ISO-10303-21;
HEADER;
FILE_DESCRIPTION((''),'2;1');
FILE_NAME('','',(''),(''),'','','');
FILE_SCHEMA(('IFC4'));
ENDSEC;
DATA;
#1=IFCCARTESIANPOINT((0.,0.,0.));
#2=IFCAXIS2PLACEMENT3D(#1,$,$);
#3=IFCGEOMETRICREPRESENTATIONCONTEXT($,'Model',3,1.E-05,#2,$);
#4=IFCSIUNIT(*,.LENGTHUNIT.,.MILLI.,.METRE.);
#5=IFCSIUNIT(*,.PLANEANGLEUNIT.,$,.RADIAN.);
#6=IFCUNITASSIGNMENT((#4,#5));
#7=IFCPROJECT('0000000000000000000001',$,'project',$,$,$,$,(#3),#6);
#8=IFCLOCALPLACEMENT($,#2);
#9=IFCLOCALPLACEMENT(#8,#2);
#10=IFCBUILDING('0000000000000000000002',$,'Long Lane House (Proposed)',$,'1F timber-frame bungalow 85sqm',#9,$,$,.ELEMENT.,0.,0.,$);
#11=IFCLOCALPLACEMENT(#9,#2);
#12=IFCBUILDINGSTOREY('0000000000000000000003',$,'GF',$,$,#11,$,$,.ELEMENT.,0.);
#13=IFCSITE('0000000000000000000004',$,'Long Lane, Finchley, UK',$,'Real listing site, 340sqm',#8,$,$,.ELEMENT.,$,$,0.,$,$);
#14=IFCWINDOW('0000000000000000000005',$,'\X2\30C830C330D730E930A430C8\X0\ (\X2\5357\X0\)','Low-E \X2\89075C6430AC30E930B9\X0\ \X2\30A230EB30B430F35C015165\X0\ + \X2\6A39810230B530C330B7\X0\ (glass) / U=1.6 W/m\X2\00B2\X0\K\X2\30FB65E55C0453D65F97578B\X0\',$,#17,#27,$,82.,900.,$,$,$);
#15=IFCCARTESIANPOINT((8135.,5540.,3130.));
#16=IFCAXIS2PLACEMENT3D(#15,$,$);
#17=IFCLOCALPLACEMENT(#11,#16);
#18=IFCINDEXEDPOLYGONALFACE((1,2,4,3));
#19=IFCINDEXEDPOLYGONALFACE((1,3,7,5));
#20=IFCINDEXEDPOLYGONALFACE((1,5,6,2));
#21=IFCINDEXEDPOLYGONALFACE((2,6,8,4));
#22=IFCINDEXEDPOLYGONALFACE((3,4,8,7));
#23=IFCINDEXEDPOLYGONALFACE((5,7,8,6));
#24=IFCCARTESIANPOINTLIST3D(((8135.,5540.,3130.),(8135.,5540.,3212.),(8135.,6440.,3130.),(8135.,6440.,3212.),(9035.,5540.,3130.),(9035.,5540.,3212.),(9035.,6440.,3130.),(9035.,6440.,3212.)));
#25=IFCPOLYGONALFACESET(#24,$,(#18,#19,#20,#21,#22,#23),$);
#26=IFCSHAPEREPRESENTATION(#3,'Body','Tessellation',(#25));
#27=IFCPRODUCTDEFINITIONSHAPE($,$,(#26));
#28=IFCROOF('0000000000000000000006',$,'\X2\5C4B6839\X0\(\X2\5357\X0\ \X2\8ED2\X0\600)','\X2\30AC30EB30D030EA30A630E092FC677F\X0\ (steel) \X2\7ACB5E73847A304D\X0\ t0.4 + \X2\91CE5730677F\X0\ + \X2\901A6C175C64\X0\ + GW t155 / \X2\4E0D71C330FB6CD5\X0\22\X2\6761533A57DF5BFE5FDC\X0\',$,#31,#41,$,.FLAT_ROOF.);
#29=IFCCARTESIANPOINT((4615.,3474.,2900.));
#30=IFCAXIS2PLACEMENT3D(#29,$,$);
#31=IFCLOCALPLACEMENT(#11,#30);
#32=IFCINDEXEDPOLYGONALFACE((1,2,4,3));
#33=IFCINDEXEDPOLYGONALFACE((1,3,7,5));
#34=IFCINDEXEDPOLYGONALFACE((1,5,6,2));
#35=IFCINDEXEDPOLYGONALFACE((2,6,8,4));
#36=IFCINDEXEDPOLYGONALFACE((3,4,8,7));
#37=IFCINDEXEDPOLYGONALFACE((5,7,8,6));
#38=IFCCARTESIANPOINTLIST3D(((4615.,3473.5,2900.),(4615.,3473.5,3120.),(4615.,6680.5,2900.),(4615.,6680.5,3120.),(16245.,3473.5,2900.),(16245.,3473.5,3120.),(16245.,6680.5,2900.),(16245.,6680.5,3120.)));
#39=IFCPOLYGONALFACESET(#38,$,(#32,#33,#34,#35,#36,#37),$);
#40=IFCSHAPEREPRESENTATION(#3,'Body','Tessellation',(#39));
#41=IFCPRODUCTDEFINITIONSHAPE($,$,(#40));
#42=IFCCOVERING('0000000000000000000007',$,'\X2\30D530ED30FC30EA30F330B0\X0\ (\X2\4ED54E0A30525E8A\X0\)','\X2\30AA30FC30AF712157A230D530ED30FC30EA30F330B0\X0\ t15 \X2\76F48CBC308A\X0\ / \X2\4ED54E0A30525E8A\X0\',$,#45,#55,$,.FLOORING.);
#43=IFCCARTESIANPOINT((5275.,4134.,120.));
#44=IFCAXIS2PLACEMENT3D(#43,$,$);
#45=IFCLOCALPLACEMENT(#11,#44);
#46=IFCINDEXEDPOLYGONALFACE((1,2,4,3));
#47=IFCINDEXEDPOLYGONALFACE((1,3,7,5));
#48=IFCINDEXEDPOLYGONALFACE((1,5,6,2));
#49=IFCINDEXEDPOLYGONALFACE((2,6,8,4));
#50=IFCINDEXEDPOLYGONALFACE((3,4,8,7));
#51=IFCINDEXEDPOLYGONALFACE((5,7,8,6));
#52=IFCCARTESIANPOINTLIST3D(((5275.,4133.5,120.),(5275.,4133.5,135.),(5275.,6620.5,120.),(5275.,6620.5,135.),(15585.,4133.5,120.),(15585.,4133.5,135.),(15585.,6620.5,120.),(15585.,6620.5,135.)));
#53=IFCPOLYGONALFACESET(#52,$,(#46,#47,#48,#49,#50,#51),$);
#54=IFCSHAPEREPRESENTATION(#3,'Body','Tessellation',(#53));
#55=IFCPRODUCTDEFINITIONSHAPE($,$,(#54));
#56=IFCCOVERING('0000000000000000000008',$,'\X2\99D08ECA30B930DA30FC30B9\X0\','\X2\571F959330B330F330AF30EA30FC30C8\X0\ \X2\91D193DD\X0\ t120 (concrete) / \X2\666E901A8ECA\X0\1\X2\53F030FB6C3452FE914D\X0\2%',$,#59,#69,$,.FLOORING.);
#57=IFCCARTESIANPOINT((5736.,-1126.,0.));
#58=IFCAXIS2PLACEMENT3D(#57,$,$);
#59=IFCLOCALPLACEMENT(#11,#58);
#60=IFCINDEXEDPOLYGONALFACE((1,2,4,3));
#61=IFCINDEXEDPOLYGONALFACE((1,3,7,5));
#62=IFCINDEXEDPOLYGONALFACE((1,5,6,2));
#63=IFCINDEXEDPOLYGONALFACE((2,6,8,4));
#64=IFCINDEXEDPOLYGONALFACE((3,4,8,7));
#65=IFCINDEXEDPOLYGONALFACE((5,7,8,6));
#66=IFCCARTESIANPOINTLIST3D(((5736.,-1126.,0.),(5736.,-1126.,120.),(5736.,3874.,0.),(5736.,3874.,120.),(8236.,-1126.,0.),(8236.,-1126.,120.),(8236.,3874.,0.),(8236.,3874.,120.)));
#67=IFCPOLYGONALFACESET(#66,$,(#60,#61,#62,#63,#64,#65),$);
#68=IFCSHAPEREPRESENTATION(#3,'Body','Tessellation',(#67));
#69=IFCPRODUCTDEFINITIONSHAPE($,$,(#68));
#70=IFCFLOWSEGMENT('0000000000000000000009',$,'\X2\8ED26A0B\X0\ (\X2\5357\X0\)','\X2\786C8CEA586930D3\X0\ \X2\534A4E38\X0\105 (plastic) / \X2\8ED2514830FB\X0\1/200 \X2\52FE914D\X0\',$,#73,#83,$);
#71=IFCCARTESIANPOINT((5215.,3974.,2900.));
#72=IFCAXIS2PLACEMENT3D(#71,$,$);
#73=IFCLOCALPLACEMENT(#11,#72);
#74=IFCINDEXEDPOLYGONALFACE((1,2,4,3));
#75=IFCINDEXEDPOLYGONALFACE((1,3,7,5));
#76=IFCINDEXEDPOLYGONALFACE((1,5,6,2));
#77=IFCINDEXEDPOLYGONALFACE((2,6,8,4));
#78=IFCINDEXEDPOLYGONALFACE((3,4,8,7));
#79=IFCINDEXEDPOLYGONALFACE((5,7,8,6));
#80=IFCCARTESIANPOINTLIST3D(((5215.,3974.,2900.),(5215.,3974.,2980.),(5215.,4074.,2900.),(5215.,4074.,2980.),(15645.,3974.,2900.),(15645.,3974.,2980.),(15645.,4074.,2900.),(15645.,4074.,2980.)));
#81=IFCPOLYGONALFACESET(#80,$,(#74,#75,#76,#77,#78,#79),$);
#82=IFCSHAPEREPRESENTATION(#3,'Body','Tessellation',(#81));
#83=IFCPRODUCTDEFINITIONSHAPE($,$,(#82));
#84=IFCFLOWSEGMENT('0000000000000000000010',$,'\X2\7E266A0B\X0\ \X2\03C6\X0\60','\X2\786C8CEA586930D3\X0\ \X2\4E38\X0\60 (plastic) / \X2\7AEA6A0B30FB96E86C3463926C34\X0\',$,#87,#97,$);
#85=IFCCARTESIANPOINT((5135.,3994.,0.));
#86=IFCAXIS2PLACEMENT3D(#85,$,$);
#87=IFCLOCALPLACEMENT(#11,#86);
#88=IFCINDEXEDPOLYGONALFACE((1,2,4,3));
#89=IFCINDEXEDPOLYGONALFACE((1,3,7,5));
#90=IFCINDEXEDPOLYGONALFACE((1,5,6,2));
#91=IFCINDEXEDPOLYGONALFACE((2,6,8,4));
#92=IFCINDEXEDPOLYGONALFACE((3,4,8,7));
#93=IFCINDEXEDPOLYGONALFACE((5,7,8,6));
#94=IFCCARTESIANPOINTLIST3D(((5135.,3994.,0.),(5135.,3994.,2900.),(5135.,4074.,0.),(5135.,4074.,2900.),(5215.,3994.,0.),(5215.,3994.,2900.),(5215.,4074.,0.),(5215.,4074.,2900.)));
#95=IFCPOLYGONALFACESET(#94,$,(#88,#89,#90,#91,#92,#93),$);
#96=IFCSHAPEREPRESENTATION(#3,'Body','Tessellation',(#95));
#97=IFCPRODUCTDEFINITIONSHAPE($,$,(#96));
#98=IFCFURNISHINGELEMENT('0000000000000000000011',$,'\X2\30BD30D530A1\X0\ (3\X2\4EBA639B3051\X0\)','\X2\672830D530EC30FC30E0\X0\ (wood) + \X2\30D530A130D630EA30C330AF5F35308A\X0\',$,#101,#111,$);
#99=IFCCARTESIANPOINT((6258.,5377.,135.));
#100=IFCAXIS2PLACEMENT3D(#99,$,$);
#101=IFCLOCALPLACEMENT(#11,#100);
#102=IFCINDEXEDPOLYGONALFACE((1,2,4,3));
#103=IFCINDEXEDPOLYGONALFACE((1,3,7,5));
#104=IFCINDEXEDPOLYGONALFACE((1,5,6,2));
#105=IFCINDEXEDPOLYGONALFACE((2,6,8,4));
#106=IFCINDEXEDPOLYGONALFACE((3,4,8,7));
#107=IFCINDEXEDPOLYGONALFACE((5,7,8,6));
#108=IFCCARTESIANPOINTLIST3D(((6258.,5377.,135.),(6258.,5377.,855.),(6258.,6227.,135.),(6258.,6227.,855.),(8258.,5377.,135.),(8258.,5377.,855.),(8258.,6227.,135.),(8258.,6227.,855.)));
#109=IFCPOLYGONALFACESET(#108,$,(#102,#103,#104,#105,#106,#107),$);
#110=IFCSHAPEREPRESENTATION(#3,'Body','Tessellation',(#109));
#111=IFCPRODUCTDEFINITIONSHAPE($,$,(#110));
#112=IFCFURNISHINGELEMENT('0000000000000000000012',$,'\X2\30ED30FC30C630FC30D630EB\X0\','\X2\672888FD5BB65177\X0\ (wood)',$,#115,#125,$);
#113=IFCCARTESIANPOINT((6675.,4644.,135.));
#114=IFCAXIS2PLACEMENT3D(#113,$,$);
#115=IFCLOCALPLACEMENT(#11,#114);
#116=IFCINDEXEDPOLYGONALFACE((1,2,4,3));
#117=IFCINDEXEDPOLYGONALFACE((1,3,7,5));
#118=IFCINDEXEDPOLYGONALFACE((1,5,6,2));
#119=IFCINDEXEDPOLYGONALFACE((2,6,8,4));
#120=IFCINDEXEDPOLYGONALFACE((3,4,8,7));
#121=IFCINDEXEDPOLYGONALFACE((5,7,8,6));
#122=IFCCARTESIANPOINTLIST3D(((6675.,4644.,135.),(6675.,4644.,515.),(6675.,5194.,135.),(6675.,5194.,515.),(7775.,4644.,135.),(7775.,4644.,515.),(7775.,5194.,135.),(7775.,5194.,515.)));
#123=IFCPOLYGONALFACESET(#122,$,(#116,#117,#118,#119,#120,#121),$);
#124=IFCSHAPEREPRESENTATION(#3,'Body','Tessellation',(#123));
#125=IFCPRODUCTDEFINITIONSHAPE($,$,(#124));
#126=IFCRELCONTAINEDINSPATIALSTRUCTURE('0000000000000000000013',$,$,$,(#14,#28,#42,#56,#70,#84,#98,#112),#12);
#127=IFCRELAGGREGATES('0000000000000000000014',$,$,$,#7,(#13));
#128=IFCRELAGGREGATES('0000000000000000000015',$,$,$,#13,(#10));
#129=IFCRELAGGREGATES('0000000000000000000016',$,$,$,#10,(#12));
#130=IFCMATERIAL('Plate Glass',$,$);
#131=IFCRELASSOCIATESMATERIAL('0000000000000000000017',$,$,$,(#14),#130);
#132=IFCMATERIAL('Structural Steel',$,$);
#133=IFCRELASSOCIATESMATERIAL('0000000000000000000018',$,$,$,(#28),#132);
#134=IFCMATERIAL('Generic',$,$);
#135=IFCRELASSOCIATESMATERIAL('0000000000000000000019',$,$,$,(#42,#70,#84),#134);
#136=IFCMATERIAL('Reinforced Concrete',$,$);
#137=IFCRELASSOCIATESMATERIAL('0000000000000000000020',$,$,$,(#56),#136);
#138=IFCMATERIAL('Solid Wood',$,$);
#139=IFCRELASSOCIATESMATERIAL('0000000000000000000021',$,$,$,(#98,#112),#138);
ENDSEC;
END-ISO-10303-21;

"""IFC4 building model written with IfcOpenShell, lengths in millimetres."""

from ifc_helpers import new_model, si_unit, frame, frame_2d, origin, place, context, project, spatial, rectangle, extrude, material, element, save


model = new_model("IFC4")

# Units and contexts
model_context = context("Model", 3, precision=1e-05, world=origin())
ifc_project = project(units=[si_unit("LENGTHUNIT", "METRE", prefix="MILLI"), si_unit("PLANEANGLEUNIT", "RADIAN")], contexts=[model_context])

# Site, building, storey
site_placement = place(None, origin())
site = spatial("IfcSite", under=ifc_project, at=site_placement, Name="Long Lane, Finchley, UK", ObjectType="Real listing site, 340sqm", CompositionType="ELEMENT", RefElevation=0.0)
building_placement = place(site_placement, origin())
building = spatial("IfcBuilding", under=site, at=building_placement, Name="Long Lane House (Proposed)", ObjectType="1F timber-frame bungalow 85sqm", CompositionType="ELEMENT", ElevationOfRefHeight=0.0, ElevationOfTerrain=0.0)
storey_placement = place(building_placement, origin())
storey = spatial("IfcBuildingStorey", under=building, at=storey_placement, Name="GF", CompositionType="ELEMENT", Elevation=0.0)

# Shared definitions
ifc_material_1 = material(Name="Solid Wood")

# Shared definitions
ifc_material_2 = material(Name="Reinforced Concrete")

# Shared definitions
ifc_material_3 = material(Name="Plate Glass")

# Window
window_1_placement = place(storey_placement, frame((8135.0, 5540.0, 3130.0)))
element("IfcWindow", 1, at=window_1_placement, inside=storey, material=ifc_material_3, Name="トップライト (南)", Description="Low-E 複層ガラス アルゴン封入 + 樹脂サッシ (glass) / U=1.6 W/m²K・日射取得型", OverallHeight=82.0, OverallWidth=900.0, context=model_context, shape_type="SweptSolid", body=[
    extrude(rectangle(XDim=900.0, YDim=900.0, at=frame_2d((450.0, 450.0))), frame((8135.0, 5540.0, 3130.0)), (0.0, 0.0, 1.0), 82.0),
])

# Roof
ifc_material_4 = material(Name="Structural Steel")
roof_1_placement = place(storey_placement, frame((4615.0, 3474.0, 2900.0)))
element("IfcRoof", 2, at=roof_1_placement, inside=storey, material=ifc_material_4, Name="屋根(南 軒600)", Description="ガルバリウム鋼板 (steel) 立平葺き t0.4 + 野地板 + 通気層 + GW t155 / 不燃・法22条区域対応", PredefinedType="FLAT_ROOF", context=model_context, shape_type="SweptSolid", body=[
    extrude(rectangle(XDim=11630.0, YDim=3207.0, at=frame_2d((5815.0, 1603.0))), frame((4615.0, 3474.0, 2900.0)), (0.0, 0.0, 1.0), 220.0),
])

# Coverings
ifc_material_5 = material(Name="Generic")
covering_1_placement = place(storey_placement, frame((5275.0, 4134.0, 120.0)))
element("IfcCovering", 3, at=covering_1_placement, inside=storey, material=ifc_material_5, Name="フローリング (仕上げ床)", Description="オーク無垢フローリング t15 直貼り / 仕上げ床", PredefinedType="FLOORING", context=model_context, shape_type="SweptSolid", body=[
    extrude(rectangle(XDim=10310.0, YDim=2487.0, at=frame_2d((5155.0, 1243.0))), frame((5275.0, 4134.0, 120.0)), (0.0, 0.0, 1.0), 15.0),
])
covering_2_placement = place(storey_placement, frame((5736.0, -1126.0, 0.0)))
element("IfcCovering", 4, at=covering_2_placement, inside=storey, material=ifc_material_2, Name="駐車スペース", Description="土間コンクリート 金鏝 t120 (concrete) / 普通車1台・水勾配2%", PredefinedType="FLOORING", context=model_context, shape_type="SweptSolid", body=[
    extrude(rectangle(XDim=2500.0, YDim=5000.0, at=frame_2d((1250.0, 2500.0))), frame((5736.0, -1126.0, 0.0)), (0.0, 0.0, 1.0), 120.0),
])

# Flow segments
flow_segment_1_placement = place(storey_placement, frame((5215.0, 3974.0, 2900.0)))
element("IfcFlowSegment", 5, at=flow_segment_1_placement, inside=storey, material=ifc_material_5, Name="軒樋 (南)", Description="硬質塩ビ 半丸105 (plastic) / 軒先・1/200 勾配", context=model_context, shape_type="SweptSolid", body=[
    extrude(rectangle(XDim=10430.0, YDim=100.0, at=frame_2d((5215.0, 50.0))), frame((5215.0, 3974.0, 2900.0)), (0.0, 0.0, 1.0), 80.0),
])
flow_segment_2_placement = place(storey_placement, frame((5135.0, 3994.0, 0.0)))
element("IfcFlowSegment", 6, at=flow_segment_2_placement, inside=storey, material=ifc_material_5, Name="縦樋 φ60", Description="硬質塩ビ 丸60 (plastic) / 竪樋・雨水排水", context=model_context, shape_type="SweptSolid", body=[
    extrude(rectangle(XDim=80.0, YDim=80.0, at=frame_2d((40.0, 40.0))), frame((5135.0, 3994.0, 0.0)), (0.0, 0.0, 1.0), 2900.0),
])

# Furnishing elements
furnishing_1_placement = place(storey_placement, frame((6258.0, 5377.0, 135.0)))
element("IfcFurnishingElement", 7, at=furnishing_1_placement, inside=storey, material=ifc_material_1, Name="ソファ (3人掛け)", Description="木フレーム (wood) + ファブリック張り", context=model_context, shape_type="SweptSolid", body=[
    extrude(rectangle(XDim=2000.0, YDim=850.0, at=frame_2d((1000.0, 425.0))), frame((6258.0, 5377.0, 135.0)), (0.0, 0.0, 1.0), 720.0),
])
furnishing_2_placement = place(storey_placement, frame((6675.0, 4644.0, 135.0)))
element("IfcFurnishingElement", 8, at=furnishing_2_placement, inside=storey, material=ifc_material_1, Name="ローテーブル", Description="木製家具 (wood)", context=model_context, shape_type="SweptSolid", body=[
    extrude(rectangle(XDim=1100.0, YDim=550.0, at=frame_2d((550.0, 275.0))), frame((6675.0, 4644.0, 135.0)), (0.0, 0.0, 1.0), 380.0),
])

save(model, "model.ifc")
